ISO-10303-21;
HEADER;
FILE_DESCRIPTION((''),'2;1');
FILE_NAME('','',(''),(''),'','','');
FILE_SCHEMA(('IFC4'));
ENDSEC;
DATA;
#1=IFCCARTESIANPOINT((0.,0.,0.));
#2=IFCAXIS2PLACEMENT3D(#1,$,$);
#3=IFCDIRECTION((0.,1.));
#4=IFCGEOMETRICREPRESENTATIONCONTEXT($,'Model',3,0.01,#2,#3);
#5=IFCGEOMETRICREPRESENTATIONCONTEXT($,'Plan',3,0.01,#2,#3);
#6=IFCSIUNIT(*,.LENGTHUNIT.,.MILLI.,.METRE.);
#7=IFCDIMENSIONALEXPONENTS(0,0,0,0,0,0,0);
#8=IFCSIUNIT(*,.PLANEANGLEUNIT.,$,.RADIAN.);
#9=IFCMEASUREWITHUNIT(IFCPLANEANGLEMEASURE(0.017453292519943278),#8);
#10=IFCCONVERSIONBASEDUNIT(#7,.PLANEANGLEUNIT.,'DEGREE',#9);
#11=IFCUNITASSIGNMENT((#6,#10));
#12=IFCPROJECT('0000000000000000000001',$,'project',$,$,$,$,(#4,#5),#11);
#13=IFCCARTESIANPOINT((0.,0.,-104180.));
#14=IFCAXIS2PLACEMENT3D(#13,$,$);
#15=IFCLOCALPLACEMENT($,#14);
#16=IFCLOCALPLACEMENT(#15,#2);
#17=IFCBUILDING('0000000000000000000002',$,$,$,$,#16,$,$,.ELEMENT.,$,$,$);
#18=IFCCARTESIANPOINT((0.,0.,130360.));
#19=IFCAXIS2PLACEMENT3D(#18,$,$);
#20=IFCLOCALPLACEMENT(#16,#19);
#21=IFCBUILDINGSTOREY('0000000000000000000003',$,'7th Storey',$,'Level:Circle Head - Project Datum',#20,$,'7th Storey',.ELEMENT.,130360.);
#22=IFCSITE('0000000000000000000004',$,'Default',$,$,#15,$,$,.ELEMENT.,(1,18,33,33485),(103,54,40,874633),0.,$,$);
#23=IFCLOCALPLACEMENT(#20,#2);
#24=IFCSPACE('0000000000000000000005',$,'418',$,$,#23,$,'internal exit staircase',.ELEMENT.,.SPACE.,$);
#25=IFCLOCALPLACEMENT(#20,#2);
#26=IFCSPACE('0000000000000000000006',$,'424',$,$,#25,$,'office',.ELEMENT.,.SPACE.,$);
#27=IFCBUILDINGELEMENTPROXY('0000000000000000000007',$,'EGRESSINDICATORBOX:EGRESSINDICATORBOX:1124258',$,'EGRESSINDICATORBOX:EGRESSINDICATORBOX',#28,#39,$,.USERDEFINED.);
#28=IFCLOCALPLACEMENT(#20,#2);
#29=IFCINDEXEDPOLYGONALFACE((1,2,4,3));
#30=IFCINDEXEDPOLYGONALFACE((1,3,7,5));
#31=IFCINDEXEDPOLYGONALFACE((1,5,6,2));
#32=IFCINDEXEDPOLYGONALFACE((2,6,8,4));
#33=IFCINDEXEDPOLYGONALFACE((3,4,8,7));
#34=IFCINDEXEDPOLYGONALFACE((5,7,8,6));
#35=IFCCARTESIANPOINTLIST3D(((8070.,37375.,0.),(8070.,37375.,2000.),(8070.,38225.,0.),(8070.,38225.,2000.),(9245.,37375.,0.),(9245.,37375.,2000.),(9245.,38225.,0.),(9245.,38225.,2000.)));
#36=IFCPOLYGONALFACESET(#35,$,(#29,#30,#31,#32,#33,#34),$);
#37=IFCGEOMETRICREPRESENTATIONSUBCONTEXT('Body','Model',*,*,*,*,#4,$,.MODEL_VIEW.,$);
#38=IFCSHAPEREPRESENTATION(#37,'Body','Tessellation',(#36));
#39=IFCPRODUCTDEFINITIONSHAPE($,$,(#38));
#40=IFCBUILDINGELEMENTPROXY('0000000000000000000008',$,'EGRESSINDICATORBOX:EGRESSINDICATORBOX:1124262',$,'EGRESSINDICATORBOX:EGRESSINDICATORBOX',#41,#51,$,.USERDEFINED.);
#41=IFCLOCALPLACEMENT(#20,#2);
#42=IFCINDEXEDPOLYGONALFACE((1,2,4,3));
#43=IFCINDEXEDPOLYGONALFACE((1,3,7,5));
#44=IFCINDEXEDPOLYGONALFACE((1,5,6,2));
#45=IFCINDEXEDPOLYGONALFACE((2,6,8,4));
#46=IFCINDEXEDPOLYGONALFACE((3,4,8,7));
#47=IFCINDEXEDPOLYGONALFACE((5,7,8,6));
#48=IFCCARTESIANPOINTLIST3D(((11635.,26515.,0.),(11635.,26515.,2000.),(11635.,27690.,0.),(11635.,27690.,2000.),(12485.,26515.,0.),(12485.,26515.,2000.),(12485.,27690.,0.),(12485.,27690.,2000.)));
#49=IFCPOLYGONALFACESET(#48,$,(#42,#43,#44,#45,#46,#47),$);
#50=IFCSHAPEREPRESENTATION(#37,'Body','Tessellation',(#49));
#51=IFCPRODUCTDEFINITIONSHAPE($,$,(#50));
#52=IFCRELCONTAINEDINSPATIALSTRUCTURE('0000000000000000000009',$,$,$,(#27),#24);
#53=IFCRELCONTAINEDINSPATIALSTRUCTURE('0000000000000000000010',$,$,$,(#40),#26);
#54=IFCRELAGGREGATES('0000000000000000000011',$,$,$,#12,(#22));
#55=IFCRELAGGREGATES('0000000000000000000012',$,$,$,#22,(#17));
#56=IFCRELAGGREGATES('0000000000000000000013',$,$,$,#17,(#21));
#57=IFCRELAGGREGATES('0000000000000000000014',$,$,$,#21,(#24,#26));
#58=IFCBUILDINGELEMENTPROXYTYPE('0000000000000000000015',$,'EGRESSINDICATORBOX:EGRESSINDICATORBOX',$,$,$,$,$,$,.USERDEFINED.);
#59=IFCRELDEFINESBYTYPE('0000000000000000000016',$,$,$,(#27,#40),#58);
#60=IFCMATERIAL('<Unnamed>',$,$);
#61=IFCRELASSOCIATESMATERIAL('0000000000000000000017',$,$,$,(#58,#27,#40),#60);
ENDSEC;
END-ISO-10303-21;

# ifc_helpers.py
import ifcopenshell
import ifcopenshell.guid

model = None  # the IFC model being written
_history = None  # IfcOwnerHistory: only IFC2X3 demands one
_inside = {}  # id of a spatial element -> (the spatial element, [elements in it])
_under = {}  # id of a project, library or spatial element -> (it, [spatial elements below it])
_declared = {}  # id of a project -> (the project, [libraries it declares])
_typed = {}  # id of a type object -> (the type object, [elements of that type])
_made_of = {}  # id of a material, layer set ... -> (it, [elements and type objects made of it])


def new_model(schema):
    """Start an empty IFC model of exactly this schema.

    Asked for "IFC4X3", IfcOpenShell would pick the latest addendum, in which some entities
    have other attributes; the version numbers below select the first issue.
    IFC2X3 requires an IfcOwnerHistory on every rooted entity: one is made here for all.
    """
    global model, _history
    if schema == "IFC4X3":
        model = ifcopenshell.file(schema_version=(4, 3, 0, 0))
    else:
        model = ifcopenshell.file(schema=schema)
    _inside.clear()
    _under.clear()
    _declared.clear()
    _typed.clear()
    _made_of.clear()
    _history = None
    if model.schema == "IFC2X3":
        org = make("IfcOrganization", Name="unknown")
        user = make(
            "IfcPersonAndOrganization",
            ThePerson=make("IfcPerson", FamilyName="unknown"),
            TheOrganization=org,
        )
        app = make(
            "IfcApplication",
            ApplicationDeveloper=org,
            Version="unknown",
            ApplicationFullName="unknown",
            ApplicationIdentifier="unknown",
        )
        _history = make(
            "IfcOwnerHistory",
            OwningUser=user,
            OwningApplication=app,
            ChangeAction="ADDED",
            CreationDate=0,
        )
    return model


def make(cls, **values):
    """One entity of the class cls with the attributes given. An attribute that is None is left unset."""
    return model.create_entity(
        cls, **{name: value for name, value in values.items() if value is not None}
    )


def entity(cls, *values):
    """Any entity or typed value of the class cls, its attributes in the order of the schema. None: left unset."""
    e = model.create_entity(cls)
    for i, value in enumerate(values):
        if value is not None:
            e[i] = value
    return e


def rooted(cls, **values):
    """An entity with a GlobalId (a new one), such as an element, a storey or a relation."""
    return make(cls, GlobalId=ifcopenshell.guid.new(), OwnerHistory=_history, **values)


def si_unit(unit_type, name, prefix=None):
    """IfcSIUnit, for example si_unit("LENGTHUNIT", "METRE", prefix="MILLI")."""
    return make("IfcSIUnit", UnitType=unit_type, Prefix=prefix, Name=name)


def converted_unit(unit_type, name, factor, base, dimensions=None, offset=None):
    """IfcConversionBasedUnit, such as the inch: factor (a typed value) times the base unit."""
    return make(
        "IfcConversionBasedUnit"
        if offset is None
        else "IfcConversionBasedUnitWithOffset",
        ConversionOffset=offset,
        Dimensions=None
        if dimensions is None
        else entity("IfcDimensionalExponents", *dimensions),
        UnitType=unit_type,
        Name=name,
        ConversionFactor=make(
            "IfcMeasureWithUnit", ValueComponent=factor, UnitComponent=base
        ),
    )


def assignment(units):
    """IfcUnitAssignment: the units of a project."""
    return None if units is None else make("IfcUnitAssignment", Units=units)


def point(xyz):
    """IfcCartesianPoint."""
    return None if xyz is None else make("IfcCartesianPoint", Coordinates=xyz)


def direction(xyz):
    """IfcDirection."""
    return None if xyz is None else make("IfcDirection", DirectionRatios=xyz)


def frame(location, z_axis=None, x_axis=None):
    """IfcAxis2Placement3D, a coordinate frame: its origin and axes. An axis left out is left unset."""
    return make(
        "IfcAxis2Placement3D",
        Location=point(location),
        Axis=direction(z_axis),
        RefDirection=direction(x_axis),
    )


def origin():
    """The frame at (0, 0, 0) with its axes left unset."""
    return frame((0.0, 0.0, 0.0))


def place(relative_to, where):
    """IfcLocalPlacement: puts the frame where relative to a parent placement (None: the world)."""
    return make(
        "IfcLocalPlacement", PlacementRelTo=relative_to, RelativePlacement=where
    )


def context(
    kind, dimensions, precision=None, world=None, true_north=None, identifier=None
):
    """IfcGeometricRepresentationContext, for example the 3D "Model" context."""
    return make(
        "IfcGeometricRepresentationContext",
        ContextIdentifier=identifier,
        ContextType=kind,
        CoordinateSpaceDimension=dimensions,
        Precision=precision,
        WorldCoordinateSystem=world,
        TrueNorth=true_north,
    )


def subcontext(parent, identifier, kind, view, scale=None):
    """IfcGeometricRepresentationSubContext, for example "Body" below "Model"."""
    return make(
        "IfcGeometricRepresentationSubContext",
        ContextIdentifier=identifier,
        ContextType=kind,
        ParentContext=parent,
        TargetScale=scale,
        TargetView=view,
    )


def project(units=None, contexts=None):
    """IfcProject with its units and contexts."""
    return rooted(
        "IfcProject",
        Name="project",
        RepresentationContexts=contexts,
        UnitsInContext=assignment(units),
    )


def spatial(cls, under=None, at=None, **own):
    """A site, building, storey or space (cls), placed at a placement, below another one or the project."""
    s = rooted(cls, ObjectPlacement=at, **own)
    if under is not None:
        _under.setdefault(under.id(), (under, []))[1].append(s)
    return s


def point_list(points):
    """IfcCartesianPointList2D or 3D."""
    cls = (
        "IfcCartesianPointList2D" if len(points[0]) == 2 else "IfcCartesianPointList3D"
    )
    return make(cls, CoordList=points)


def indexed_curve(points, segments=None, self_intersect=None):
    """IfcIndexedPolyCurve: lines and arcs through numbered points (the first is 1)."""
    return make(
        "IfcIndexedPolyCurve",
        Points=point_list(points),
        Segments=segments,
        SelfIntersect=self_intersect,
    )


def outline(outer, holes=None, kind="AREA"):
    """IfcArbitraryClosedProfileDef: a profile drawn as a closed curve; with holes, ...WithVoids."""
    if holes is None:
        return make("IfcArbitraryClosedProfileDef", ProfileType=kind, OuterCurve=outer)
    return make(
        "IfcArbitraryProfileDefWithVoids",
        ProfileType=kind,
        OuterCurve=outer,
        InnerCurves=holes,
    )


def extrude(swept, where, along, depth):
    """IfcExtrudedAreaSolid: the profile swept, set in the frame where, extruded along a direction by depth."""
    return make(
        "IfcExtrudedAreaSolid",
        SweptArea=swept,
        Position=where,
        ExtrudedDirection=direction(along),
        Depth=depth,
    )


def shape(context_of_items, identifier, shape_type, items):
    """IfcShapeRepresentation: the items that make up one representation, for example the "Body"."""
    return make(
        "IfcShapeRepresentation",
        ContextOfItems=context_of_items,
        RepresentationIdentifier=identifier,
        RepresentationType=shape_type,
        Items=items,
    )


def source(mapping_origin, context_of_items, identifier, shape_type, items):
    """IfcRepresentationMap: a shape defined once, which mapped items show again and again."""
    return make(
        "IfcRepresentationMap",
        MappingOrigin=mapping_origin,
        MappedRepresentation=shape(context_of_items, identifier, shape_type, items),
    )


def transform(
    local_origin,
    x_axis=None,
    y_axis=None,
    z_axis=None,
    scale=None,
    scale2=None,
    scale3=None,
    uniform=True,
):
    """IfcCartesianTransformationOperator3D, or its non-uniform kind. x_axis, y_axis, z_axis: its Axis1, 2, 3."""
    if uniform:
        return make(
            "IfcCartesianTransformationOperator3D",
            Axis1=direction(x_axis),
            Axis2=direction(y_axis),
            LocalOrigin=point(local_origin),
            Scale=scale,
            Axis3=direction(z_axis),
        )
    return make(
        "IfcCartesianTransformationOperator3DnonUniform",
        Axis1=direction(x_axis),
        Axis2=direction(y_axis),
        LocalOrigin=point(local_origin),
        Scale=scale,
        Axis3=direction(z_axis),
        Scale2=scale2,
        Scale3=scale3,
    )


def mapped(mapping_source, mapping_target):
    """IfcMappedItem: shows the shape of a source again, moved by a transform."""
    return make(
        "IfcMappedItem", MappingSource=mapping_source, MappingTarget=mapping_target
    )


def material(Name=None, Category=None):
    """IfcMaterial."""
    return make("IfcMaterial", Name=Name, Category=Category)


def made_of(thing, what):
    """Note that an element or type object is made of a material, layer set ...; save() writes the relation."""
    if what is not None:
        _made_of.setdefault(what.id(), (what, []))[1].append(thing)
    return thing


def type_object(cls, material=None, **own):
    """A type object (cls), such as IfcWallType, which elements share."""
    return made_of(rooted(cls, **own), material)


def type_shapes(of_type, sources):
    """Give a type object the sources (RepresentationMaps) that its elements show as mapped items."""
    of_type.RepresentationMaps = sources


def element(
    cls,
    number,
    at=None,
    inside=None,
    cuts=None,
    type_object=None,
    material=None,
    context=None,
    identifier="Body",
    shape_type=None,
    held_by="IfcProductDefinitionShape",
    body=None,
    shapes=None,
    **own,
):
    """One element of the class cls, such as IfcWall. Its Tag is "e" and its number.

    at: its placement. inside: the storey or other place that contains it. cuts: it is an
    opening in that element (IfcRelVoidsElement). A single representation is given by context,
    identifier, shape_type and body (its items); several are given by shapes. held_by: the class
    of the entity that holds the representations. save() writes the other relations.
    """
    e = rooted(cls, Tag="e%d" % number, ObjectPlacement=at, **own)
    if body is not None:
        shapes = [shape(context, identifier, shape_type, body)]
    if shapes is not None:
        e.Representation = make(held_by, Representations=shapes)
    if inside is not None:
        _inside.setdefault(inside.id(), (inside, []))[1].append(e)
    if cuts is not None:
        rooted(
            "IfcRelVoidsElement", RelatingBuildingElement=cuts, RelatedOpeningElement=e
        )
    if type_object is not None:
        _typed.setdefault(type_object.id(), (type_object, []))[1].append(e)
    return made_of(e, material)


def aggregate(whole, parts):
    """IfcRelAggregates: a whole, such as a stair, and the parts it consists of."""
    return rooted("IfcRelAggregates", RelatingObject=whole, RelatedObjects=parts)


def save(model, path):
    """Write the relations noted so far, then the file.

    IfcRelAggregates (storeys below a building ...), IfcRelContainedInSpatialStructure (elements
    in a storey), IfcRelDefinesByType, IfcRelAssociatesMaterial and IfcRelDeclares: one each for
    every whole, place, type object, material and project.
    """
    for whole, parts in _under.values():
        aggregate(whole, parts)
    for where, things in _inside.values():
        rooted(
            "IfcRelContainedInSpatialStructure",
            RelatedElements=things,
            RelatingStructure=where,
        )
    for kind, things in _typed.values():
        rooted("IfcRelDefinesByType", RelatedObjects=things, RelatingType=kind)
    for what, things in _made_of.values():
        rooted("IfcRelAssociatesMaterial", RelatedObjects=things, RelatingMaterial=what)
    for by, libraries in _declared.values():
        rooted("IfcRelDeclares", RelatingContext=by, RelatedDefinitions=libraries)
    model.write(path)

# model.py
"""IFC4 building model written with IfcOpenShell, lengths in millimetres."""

from ifc_helpers import new_model, entity, si_unit, converted_unit, direction, frame, origin, place, context, subcontext, project, spatial, indexed_curve, outline, extrude, source, transform, mapped, material, type_object, type_shapes, element, save


model = new_model("IFC4")

# Units and contexts
model_context = context("Model", 3, precision=0.01, world=origin(), true_north=direction((0.0, 1.0)))
plan_context = context("Plan", 3, precision=0.01, world=origin(), true_north=direction((0.0, 1.0)))
body_context = subcontext(model_context, "Body", "Model", "MODEL_VIEW")
ifc_project = project(units=[si_unit("LENGTHUNIT", "METRE", prefix="MILLI"), converted_unit("PLANEANGLEUNIT", "DEGREE", entity("IfcPlaneAngleMeasure", 0.017453292519943278), si_unit("PLANEANGLEUNIT", "RADIAN"), dimensions=[0, 0, 0, 0, 0, 0, 0])], contexts=[model_context, plan_context])

# Site, building, storey
site_placement = place(None, frame((0.0, 0.0, -104180.0)))
site = spatial("IfcSite", under=ifc_project, at=site_placement, Name="Default", CompositionType="ELEMENT", RefLatitude=(1, 18, 33, 33485), RefLongitude=(103, 54, 40, 874633), RefElevation=0.0)
building_placement = place(site_placement, origin())
building = spatial("IfcBuilding", under=site, at=building_placement, CompositionType="ELEMENT")
storey_placement = place(building_placement, frame((0.0, 0.0, 130360.0)))
storey = spatial("IfcBuildingStorey", under=building, at=storey_placement, Name="7th Storey", ObjectType="Level:Circle Head - Project Datum", LongName="7th Storey", CompositionType="ELEMENT", Elevation=130360.0)

# Shared definitions
ifc_material_1 = material(Name="<Unnamed>")

# Shared definitions
building_element_proxy_type_1 = type_object("IfcBuildingElementProxyType", Name="EGRESSINDICATORBOX:EGRESSINDICATORBOX", PredefinedType="USERDEFINED", material=ifc_material_1)
shared_shape_1 = source(origin(), body_context, "Body", "SweptSolid", [
    extrude(outline(indexed_curve([(-425.0, -587.5), (425.0, -587.5), (425.0, 587.5), (-425.0, 587.5), (-425.0, -587.5)], self_intersect=False)), frame((0.0, 0.0, 0.0), z_axis=(0.0, 0.0, 1.0), x_axis=(-1.0, 0.0, 0.0)), (0.0, 0.0, 1.0), 2000.0),
])
type_shapes(building_element_proxy_type_1, [shared_shape_1])

# Shared definitions
space_1_placement = place(storey_placement, origin())
space_1 = spatial("IfcSpace", under=storey, at=space_1_placement, Name="418", LongName="internal exit staircase", CompositionType="ELEMENT", PredefinedType="SPACE")

# Building element proxy
proxy_1_placement = place(space_1_placement, frame((8657.5, 37800.0, 0.0), z_axis=(0.0, 0.0, 1.0), x_axis=(0.0, 1.0, 0.0)))
element("IfcBuildingElementProxy", 1, at=proxy_1_placement, inside=space_1, type_object=building_element_proxy_type_1, material=ifc_material_1, Name="EGRESSINDICATORBOX:EGRESSINDICATORBOX:1124258", ObjectType="EGRESSINDICATORBOX:EGRESSINDICATORBOX", PredefinedType="USERDEFINED", context=body_context, shape_type="MappedRepresentation", body=[
    mapped(shared_shape_1, transform((0.0, 0.0, 0.0), scale=1.0)),
])

# Shared definitions
space_2_placement = place(storey_placement, origin())
space_2 = spatial("IfcSpace", under=storey, at=space_2_placement, Name="424", LongName="office", CompositionType="ELEMENT", PredefinedType="SPACE")

# Building element proxy
proxy_2_placement = place(space_2_placement, frame((12060.0, 27102.5, 0.0)))
element("IfcBuildingElementProxy", 2, at=proxy_2_placement, inside=space_2, type_object=building_element_proxy_type_1, material=ifc_material_1, Name="EGRESSINDICATORBOX:EGRESSINDICATORBOX:1124262", ObjectType="EGRESSINDICATORBOX:EGRESSINDICATORBOX", PredefinedType="USERDEFINED", context=body_context, shape_type="MappedRepresentation", body=[
    mapped(shared_shape_1, transform((0.0, 0.0, 0.0), scale=1.0)),
])

save(model, "model.ifc")
